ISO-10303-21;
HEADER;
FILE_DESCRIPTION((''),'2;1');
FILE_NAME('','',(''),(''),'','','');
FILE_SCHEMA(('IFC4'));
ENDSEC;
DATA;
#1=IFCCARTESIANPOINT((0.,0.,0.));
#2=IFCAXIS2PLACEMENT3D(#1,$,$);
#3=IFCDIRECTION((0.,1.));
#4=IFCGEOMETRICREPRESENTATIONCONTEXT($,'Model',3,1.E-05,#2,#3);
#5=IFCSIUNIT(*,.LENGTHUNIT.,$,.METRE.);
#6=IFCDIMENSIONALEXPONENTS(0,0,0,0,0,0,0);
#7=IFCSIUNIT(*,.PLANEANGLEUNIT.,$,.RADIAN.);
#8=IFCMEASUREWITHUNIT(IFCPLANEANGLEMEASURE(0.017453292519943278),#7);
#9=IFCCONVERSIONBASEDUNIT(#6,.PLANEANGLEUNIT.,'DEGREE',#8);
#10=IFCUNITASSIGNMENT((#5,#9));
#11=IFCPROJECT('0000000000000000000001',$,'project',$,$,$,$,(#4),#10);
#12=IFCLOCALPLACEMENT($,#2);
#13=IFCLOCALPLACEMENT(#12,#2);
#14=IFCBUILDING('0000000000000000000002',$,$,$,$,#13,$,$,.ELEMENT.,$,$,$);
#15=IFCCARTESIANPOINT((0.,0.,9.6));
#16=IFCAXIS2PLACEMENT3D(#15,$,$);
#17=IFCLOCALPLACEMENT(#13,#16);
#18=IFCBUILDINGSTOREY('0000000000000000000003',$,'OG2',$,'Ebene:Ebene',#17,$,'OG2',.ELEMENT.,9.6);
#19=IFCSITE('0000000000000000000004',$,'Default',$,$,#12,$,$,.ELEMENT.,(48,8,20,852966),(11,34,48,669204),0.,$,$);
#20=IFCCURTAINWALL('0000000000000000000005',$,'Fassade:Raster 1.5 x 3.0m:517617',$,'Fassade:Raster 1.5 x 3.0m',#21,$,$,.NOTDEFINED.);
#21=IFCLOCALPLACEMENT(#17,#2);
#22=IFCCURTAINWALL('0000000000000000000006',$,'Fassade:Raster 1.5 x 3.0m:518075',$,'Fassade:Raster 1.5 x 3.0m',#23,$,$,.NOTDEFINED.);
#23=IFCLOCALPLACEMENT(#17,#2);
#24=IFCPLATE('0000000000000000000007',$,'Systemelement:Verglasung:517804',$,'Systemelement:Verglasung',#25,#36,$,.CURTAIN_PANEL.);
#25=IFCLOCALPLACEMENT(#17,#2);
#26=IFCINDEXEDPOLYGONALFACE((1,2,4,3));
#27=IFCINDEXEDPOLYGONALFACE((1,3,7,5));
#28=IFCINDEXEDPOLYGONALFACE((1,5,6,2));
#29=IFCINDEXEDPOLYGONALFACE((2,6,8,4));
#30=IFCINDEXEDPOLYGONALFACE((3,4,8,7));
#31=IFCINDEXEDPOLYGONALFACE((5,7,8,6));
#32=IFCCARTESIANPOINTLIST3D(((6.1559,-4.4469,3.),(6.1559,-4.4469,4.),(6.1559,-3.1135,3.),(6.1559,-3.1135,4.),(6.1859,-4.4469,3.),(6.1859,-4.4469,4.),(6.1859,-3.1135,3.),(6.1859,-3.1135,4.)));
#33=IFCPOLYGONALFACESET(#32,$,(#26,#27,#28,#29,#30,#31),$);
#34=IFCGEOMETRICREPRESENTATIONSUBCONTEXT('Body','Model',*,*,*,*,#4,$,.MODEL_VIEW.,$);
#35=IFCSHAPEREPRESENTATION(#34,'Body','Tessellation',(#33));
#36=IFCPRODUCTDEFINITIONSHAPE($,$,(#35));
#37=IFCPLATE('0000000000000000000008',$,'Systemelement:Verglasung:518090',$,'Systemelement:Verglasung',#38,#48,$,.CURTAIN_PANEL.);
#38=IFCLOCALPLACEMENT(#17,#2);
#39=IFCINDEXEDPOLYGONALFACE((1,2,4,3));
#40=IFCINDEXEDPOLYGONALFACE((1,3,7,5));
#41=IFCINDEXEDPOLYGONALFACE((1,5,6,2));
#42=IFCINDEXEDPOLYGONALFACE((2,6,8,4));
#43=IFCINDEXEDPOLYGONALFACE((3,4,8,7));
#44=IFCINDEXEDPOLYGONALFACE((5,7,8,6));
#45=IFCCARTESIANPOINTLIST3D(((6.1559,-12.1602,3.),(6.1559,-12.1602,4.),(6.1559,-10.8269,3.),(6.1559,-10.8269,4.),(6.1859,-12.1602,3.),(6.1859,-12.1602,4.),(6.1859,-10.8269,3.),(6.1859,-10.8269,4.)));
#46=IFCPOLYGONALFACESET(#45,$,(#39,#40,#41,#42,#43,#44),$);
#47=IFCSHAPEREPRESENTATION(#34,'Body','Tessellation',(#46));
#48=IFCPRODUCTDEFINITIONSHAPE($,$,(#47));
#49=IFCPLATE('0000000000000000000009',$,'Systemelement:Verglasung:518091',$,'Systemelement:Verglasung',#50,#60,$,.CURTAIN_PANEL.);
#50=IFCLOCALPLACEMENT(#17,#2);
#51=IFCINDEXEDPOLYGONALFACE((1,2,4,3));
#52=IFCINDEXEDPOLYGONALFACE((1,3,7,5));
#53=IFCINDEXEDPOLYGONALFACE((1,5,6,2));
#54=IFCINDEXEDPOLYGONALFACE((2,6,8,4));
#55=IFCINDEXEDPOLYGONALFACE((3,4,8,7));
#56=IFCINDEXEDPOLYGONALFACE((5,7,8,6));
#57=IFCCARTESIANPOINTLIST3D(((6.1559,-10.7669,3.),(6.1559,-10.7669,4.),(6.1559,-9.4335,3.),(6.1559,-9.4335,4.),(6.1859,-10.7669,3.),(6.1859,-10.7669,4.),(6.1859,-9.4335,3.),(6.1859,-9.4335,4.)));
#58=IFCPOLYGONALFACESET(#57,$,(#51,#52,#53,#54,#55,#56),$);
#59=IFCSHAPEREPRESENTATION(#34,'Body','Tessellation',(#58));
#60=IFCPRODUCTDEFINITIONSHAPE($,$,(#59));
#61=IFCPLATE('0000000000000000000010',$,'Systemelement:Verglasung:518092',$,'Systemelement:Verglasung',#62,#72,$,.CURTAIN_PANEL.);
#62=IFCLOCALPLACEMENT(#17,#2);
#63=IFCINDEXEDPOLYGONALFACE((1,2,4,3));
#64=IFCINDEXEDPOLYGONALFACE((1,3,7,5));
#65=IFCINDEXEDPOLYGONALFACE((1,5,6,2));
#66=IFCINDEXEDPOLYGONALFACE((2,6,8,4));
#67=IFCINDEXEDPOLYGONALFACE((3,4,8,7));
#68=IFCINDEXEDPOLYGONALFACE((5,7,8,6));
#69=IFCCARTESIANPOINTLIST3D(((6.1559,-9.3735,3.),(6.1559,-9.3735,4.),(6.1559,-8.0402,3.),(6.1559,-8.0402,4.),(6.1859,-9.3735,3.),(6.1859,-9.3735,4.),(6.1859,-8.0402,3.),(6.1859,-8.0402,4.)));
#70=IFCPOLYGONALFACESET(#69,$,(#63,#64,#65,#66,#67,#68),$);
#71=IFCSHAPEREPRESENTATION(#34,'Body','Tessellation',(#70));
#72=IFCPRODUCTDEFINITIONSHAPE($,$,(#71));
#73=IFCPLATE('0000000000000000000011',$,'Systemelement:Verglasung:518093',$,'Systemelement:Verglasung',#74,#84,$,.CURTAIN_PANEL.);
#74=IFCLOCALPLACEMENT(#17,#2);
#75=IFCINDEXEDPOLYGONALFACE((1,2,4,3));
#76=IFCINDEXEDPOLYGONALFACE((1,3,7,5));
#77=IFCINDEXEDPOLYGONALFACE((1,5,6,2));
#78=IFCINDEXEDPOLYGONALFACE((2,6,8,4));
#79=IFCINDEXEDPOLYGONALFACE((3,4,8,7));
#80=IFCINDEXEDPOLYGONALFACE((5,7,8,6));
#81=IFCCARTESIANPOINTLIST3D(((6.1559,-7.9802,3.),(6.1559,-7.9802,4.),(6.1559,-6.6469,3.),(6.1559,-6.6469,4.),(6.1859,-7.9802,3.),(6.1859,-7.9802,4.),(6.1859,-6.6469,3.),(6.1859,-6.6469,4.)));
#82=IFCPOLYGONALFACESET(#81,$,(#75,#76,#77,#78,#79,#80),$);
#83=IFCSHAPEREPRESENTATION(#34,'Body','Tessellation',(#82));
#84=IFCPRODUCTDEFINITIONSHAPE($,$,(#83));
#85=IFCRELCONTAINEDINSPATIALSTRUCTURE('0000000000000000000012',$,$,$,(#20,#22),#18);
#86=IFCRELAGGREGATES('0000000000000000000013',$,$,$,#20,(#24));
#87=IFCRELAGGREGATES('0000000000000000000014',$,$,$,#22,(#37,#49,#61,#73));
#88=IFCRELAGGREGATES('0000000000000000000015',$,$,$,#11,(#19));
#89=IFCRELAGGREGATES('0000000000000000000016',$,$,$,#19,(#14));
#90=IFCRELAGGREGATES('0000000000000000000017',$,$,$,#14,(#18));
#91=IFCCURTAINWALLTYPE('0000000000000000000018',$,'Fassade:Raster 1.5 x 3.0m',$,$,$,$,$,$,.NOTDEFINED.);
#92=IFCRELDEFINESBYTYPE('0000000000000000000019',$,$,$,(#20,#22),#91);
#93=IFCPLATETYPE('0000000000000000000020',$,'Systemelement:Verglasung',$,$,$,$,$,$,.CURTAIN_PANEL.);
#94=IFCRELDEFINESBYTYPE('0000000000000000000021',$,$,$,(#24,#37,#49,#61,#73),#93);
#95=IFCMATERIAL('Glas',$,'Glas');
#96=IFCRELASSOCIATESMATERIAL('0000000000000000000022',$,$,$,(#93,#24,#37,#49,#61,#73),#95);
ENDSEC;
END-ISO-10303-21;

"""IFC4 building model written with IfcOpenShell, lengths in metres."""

from ifc_helpers import new_model, entity, si_unit, converted_unit, direction, frame, origin, place, context, subcontext, project, spatial, indexed_curve, outline, extrude, source, transform, mapped, material, type_object, type_shapes, element, aggregate, save


model = new_model("IFC4")

# Units and contexts
model_context = context("Model", 3, precision=1e-05, world=origin(), true_north=direction((0.0, 1.0)))
body_context = subcontext(model_context, "Body", "Model", "MODEL_VIEW")
ifc_project = project(units=[si_unit("LENGTHUNIT", "METRE"), converted_unit("PLANEANGLEUNIT", "DEGREE", entity("IfcPlaneAngleMeasure", 0.017453292519943278), si_unit("PLANEANGLEUNIT", "RADIAN"), dimensions=[0, 0, 0, 0, 0, 0, 0])], contexts=[model_context])

# Site, building, storey
site_placement = place(None, origin())
site = spatial("IfcSite", under=ifc_project, at=site_placement, Name="Default", CompositionType="ELEMENT", RefLatitude=(48, 8, 20, 852966), RefLongitude=(11, 34, 48, 669204), RefElevation=0.0)
building_placement = place(site_placement, origin())
building = spatial("IfcBuilding", under=site, at=building_placement, CompositionType="ELEMENT")
storey_placement = place(building_placement, frame((0.0, 0.0, 9.6)))
storey = spatial("IfcBuildingStorey", under=building, at=storey_placement, Name="OG2", ObjectType="Ebene:Ebene", LongName="OG2", CompositionType="ELEMENT", Elevation=9.6)

# Curtain wall
curtain_wall_type = type_object("IfcCurtainWallType", Name="Fassade:Raster 1.5 x 3.0m", PredefinedType="NOTDEFINED")
curtain_wall_1_placement = place(storey_placement, frame((0.0, 0.0, -9.6)))
curtain_wall_1 = element("IfcCurtainWall", 1, at=curtain_wall_1_placement, inside=storey, type_object=curtain_wall_type, Name="Fassade:Raster 1.5 x 3.0m:517617", ObjectType="Fassade:Raster 1.5 x 3.0m", PredefinedType="NOTDEFINED")

# Curtain wall
curtain_wall_2_placement = place(storey_placement, frame((0.0, 0.0, -9.6)))
curtain_wall_2 = element("IfcCurtainWall", 2, at=curtain_wall_2_placement, inside=storey, type_object=curtain_wall_type, Name="Fassade:Raster 1.5 x 3.0m:518075", ObjectType="Fassade:Raster 1.5 x 3.0m", PredefinedType="NOTDEFINED")

# Plates
ifc_material_1 = material(Name="Glas", Category="Glas")
plate_type_1 = type_object("IfcPlateType", Name="Systemelement:Verglasung", PredefinedType="CURTAIN_PANEL", material=ifc_material_1)
shared_shape_1 = source(origin(), body_context, "Body", "SweptSolid", [
    extrude(outline(indexed_curve([(-0.015, -0.6667), (0.015, -0.6667), (0.015, 0.6667), (-0.015, 0.6667), (-0.015, -0.6667)], self_intersect=False)), frame((0.0, 0.0, 0.0), z_axis=(0.0, 0.0, 1.0), x_axis=(0.0, 1.0, 0.0)), (0.0, 0.0, 1.0), 1.0),
])
type_shapes(plate_type_1, [shared_shape_1])
plate_1_placement = place(curtain_wall_1_placement, frame((6.1709, -3.7802, 12.6), z_axis=(0.0, 0.0, 1.0), x_axis=(0.0, 1.0, 0.0)))
plate_1 = element("IfcPlate", 3, at=plate_1_placement, type_object=plate_type_1, material=ifc_material_1, Name="Systemelement:Verglasung:517804", ObjectType="Systemelement:Verglasung", PredefinedType="CURTAIN_PANEL", context=body_context, shape_type="MappedRepresentation", body=[
    mapped(shared_shape_1, transform((0.0, 0.0, 0.0), scale=1.0)),
])
aggregate(curtain_wall_1, [plate_1])
plate_2_placement = place(curtain_wall_2_placement, frame((6.1709, -11.4935, 12.6), z_axis=(0.0, 0.0, 1.0), x_axis=(0.0, 1.0, 0.0)))
plate_2 = element("IfcPlate", 4, at=plate_2_placement, type_object=plate_type_1, material=ifc_material_1, Name="Systemelement:Verglasung:518090", ObjectType="Systemelement:Verglasung", PredefinedType="CURTAIN_PANEL", context=body_context, shape_type="MappedRepresentation", body=[
    mapped(shared_shape_1, transform((0.0, 0.0, 0.0), scale=1.0)),
])
plate_3_placement = place(curtain_wall_2_placement, frame((6.1709, -10.1002, 12.6), z_axis=(0.0, 0.0, 1.0), x_axis=(0.0, 1.0, 0.0)))
plate_3 = element("IfcPlate", 5, at=plate_3_placement, type_object=plate_type_1, material=ifc_material_1, Name="Systemelement:Verglasung:518091", ObjectType="Systemelement:Verglasung", PredefinedType="CURTAIN_PANEL", context=body_context, shape_type="MappedRepresentation", body=[
    mapped(shared_shape_1, transform((0.0, 0.0, 0.0), scale=1.0)),
])
plate_4_placement = place(curtain_wall_2_placement, frame((6.1709, -8.7069, 12.6), z_axis=(0.0, 0.0, 1.0), x_axis=(0.0, 1.0, 0.0)))
plate_4 = element("IfcPlate", 6, at=plate_4_placement, type_object=plate_type_1, material=ifc_material_1, Name="Systemelement:Verglasung:518092", ObjectType="Systemelement:Verglasung", PredefinedType="CURTAIN_PANEL", context=body_context, shape_type="MappedRepresentation", body=[
    mapped(shared_shape_1, transform((0.0, 0.0, 0.0), scale=1.0)),
])
plate_5_placement = place(curtain_wall_2_placement, frame((6.1709, -7.3135, 12.6), z_axis=(0.0, 0.0, 1.0), x_axis=(0.0, 1.0, 0.0)))
plate_5 = element("IfcPlate", 7, at=plate_5_placement, type_object=plate_type_1, material=ifc_material_1, Name="Systemelement:Verglasung:518093", ObjectType="Systemelement:Verglasung", PredefinedType="CURTAIN_PANEL", context=body_context, shape_type="MappedRepresentation", body=[
    mapped(shared_shape_1, transform((0.0, 0.0, 0.0), scale=1.0)),
])
aggregate(curtain_wall_2, [plate_2, plate_3, plate_4, plate_5])

save(model, "model.ifc")
